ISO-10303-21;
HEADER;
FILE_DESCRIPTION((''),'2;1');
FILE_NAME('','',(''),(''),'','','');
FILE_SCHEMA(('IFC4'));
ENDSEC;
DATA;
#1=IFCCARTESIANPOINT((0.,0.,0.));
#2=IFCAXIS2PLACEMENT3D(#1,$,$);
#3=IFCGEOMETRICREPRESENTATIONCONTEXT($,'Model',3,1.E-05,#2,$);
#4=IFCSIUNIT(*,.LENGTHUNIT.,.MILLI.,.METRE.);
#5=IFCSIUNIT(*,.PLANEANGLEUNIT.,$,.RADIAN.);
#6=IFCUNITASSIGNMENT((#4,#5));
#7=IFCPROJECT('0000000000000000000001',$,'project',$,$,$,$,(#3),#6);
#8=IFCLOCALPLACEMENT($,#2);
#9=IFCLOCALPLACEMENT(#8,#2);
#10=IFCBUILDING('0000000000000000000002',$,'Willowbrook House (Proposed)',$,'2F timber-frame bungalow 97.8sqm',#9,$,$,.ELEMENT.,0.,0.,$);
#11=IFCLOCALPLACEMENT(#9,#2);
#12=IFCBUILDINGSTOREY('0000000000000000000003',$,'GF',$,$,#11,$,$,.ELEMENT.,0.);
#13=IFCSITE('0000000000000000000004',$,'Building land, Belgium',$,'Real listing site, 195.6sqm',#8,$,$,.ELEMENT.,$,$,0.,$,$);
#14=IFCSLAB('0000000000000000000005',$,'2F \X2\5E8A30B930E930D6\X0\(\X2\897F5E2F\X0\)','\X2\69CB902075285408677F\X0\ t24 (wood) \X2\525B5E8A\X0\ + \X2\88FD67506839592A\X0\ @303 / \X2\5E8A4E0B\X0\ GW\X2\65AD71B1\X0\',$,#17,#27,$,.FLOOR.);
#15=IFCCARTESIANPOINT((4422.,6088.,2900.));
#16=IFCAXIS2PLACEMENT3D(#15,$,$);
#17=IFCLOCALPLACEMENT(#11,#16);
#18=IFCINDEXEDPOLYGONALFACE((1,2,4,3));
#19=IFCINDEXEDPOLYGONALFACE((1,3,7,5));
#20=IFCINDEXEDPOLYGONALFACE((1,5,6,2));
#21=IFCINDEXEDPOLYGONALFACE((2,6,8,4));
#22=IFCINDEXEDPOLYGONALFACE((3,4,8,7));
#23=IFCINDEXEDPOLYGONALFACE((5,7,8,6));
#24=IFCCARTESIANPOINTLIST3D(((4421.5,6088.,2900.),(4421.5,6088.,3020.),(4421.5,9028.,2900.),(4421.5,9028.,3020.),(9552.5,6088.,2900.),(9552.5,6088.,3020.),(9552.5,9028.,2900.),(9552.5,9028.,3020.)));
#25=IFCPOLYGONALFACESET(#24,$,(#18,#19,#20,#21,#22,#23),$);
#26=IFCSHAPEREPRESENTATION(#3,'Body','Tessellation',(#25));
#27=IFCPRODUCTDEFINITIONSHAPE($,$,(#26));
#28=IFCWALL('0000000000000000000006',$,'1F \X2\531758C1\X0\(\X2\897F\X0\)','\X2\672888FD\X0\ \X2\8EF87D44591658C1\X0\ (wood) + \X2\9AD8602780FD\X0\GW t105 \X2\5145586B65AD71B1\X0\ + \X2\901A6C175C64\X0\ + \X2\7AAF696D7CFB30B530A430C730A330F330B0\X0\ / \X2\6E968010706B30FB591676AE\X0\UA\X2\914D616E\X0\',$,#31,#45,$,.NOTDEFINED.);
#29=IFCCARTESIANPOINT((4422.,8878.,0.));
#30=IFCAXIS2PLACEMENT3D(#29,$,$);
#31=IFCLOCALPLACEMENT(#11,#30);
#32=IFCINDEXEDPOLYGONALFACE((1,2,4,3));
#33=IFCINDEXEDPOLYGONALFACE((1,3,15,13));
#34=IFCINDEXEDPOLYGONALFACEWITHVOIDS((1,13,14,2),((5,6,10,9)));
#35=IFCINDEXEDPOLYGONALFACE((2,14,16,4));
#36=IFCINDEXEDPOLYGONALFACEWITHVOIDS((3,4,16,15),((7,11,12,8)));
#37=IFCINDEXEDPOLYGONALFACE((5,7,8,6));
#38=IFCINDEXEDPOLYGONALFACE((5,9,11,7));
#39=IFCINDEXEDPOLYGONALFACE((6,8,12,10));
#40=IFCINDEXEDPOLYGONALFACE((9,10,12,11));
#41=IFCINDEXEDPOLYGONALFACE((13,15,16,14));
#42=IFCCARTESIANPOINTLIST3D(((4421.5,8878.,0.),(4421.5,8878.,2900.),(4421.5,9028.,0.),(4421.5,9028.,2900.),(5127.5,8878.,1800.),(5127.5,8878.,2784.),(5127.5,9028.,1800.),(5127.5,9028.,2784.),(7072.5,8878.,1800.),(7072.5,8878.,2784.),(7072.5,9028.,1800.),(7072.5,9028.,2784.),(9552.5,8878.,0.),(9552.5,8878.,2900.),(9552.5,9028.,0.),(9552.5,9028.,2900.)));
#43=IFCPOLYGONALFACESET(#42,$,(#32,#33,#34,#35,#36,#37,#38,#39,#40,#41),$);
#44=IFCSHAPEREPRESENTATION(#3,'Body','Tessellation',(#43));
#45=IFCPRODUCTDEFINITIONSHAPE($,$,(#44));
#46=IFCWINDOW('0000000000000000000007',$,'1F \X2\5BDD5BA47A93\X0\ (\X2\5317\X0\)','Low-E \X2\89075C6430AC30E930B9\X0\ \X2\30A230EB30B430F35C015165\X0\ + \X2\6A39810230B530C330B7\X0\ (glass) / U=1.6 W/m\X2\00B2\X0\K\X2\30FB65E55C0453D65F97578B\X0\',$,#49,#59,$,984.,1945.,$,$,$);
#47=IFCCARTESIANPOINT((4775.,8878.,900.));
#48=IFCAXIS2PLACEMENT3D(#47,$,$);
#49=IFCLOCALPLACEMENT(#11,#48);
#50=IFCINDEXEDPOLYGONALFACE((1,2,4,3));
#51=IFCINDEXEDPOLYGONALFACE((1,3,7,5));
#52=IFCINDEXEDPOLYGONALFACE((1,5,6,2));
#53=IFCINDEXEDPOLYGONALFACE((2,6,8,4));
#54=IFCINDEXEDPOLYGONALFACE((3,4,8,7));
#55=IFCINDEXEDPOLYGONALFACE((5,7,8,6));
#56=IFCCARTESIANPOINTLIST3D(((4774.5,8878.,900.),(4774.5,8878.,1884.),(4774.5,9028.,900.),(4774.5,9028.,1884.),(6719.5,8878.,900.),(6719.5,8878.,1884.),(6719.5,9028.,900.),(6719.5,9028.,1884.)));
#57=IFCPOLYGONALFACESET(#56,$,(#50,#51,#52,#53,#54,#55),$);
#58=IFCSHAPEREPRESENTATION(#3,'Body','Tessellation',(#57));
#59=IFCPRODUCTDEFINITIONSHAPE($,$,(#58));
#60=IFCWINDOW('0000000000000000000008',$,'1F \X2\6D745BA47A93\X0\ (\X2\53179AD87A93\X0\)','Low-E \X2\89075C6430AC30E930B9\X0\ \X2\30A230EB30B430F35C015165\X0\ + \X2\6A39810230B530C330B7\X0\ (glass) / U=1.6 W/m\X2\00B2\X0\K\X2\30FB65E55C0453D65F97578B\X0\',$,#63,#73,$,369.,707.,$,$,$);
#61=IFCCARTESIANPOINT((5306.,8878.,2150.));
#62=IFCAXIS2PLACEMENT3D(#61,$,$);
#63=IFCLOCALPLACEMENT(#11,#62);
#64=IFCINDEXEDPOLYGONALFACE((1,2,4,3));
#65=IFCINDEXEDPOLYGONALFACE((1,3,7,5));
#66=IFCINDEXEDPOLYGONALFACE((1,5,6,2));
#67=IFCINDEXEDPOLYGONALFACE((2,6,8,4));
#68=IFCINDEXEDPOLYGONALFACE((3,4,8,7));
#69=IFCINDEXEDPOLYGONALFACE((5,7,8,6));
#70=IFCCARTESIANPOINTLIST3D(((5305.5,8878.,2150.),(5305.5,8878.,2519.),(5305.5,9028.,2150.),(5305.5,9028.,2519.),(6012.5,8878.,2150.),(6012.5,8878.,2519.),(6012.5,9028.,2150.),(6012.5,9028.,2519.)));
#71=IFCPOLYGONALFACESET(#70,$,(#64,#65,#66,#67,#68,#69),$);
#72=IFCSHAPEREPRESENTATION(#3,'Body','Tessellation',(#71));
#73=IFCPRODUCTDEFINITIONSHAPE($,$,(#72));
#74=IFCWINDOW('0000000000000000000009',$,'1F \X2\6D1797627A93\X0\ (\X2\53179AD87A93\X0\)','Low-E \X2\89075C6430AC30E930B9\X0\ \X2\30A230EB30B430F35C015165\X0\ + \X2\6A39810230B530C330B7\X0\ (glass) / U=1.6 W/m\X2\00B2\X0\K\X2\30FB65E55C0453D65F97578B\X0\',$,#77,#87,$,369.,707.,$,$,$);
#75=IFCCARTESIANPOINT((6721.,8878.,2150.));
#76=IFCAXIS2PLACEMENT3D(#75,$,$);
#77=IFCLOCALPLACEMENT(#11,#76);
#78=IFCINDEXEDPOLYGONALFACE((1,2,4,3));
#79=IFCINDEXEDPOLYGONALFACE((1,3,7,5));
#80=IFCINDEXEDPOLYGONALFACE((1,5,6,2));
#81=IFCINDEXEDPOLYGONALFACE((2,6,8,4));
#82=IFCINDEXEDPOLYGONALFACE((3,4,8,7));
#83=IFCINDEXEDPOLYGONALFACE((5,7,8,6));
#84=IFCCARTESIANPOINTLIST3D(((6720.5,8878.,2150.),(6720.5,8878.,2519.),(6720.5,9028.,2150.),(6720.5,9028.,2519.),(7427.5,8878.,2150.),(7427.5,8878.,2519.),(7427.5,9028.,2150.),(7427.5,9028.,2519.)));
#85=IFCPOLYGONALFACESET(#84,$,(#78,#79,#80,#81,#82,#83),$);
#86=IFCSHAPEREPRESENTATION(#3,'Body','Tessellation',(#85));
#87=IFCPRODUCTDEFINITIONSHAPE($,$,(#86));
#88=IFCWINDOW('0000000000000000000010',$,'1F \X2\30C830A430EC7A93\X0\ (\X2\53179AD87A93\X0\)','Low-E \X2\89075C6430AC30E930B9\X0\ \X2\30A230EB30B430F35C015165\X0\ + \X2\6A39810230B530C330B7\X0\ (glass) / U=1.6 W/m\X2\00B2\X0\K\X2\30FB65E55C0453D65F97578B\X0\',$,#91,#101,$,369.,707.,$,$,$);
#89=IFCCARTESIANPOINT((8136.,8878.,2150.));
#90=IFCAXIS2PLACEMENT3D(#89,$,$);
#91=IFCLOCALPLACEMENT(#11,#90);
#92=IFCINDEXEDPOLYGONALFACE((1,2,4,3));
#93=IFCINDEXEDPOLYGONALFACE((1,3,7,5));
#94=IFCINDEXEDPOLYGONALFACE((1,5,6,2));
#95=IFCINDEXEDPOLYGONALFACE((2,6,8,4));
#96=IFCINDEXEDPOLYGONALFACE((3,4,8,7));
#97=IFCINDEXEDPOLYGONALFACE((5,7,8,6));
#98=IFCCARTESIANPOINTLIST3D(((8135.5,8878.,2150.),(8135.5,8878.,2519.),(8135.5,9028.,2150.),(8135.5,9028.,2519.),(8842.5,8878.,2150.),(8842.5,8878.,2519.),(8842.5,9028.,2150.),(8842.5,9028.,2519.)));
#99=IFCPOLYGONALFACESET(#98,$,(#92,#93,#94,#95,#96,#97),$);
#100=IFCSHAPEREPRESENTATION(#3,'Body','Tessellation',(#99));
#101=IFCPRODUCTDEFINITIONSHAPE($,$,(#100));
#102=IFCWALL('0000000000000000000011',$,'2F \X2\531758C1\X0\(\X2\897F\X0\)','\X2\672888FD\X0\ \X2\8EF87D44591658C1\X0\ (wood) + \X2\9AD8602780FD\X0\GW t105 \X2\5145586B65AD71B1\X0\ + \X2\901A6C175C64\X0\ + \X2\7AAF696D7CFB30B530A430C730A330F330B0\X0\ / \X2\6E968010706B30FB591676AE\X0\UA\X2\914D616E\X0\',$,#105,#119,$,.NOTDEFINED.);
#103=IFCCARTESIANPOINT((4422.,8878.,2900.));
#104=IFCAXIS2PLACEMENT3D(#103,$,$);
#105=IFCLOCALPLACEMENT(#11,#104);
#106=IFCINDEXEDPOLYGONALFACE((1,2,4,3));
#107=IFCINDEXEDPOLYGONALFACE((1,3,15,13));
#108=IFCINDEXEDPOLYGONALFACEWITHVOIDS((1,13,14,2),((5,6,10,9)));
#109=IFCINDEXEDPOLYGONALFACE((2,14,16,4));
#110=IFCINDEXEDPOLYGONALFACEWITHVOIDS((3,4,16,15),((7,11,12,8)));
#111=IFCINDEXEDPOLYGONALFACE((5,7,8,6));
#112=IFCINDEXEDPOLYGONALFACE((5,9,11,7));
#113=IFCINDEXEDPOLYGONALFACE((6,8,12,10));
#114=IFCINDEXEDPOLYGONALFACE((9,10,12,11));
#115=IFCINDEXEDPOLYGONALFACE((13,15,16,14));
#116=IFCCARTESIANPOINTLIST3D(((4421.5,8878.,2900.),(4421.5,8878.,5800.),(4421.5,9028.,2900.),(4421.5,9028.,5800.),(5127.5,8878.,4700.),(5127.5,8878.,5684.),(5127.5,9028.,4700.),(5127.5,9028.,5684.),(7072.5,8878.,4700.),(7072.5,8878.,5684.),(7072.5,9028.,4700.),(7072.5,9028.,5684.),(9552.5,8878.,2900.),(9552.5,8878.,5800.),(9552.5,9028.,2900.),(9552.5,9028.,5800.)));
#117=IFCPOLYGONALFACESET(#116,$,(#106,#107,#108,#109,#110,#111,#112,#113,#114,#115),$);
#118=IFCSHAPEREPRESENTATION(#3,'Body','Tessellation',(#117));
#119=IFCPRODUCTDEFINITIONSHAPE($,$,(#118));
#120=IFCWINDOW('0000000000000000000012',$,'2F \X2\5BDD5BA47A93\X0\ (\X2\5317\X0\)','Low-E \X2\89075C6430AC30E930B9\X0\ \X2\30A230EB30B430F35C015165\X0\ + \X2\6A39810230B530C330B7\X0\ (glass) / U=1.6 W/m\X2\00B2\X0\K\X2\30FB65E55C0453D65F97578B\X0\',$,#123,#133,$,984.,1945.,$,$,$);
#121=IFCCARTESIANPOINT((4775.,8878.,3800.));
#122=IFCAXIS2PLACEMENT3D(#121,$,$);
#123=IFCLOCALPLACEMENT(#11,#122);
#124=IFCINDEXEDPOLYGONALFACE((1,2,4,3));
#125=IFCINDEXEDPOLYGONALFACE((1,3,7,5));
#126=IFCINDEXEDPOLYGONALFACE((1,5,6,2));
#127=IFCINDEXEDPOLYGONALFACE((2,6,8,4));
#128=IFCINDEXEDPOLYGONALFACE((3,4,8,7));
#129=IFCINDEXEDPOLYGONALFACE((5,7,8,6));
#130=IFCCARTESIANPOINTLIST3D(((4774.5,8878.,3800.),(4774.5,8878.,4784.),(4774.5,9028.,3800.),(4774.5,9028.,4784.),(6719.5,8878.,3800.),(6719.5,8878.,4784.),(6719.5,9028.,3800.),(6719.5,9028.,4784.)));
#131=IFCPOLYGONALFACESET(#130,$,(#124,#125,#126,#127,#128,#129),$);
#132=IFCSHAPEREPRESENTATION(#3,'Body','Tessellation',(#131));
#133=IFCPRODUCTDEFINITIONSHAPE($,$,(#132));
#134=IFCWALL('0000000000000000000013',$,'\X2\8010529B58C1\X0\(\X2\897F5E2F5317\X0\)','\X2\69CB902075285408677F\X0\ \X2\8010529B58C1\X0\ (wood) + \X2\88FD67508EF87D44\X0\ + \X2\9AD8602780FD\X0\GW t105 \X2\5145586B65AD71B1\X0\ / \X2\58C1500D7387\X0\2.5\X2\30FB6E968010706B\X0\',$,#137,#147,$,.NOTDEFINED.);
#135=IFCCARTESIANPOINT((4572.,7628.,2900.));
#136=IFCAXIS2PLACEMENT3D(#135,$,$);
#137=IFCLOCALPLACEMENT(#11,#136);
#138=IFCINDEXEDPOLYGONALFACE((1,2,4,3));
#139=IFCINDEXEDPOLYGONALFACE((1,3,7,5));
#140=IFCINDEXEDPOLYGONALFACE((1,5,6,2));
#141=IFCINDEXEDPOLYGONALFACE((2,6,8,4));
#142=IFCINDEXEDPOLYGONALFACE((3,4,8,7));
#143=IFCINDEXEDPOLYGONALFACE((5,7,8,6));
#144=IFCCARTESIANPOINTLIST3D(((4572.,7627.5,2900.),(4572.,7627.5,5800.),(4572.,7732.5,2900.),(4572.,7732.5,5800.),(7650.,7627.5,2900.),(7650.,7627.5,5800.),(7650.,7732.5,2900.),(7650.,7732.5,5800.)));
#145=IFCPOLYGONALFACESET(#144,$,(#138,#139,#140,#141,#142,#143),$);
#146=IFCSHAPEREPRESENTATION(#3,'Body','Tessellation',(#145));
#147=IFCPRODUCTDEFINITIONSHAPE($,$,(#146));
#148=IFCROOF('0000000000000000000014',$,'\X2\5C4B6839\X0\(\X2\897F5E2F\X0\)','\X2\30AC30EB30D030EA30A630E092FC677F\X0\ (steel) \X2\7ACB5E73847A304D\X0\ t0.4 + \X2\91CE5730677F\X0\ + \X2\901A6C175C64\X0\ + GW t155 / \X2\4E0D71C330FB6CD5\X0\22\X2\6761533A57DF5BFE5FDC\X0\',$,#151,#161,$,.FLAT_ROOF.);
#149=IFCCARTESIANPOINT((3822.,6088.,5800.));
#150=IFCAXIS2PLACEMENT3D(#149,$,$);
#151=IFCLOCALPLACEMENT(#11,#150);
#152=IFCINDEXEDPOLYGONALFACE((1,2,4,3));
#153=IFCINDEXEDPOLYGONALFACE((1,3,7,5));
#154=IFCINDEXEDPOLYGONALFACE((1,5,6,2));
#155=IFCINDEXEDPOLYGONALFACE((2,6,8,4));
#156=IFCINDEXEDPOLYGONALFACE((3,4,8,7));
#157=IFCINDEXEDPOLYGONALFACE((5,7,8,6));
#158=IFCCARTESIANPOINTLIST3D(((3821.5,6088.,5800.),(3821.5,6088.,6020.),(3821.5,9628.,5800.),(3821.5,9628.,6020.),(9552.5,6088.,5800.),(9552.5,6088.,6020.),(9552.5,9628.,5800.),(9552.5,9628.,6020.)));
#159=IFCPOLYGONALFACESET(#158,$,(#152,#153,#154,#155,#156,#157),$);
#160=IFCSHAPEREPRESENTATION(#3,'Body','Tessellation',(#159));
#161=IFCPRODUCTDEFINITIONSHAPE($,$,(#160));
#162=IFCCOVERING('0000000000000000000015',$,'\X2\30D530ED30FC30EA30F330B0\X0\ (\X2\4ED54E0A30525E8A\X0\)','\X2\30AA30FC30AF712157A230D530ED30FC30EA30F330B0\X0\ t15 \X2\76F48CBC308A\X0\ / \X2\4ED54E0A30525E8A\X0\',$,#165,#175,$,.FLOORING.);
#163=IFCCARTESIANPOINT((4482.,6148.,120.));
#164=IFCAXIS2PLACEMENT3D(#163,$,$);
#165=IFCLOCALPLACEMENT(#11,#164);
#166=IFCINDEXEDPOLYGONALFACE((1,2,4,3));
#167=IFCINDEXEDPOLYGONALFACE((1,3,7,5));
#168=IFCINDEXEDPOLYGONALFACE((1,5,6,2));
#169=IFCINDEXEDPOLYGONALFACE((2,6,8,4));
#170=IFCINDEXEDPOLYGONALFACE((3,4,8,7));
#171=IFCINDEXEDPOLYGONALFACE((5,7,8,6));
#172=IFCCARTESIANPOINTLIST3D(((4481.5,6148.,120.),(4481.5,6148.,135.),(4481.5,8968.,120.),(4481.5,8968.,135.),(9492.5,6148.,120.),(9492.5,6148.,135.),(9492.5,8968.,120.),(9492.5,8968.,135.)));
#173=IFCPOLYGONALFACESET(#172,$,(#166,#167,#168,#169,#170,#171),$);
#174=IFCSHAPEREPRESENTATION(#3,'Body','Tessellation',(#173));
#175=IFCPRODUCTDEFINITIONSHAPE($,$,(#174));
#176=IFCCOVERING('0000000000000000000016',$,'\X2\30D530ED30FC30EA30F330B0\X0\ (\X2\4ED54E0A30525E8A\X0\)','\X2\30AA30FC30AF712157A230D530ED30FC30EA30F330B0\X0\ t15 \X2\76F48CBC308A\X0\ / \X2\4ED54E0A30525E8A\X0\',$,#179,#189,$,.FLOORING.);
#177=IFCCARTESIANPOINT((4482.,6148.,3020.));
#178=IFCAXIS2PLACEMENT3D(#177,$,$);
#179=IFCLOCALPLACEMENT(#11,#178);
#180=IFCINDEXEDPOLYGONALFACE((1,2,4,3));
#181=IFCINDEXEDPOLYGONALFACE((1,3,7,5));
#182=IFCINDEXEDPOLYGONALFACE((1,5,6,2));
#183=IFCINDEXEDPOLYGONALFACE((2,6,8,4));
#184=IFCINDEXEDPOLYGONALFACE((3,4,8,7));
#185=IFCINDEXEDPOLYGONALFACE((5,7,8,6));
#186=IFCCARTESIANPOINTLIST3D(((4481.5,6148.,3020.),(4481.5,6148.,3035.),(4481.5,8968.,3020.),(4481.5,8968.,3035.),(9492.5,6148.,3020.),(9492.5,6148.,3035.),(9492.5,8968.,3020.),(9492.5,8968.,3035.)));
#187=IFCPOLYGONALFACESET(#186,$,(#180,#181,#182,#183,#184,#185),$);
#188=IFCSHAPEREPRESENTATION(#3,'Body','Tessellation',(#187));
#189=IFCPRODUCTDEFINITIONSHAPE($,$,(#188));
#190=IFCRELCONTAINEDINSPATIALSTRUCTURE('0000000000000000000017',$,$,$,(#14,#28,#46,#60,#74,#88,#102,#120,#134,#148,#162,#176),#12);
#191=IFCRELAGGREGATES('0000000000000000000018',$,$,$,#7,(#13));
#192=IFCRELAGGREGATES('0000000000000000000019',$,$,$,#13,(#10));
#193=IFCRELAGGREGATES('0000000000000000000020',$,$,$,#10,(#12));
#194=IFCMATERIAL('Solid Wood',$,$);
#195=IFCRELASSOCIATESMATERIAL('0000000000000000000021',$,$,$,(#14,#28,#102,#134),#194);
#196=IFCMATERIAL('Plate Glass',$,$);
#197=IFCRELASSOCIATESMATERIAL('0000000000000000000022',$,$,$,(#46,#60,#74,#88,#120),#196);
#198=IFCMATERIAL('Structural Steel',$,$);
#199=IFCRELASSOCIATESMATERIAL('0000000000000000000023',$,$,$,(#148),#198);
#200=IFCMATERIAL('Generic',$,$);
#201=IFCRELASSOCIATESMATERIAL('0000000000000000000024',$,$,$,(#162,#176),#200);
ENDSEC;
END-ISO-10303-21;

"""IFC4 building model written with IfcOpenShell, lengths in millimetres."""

from ifc_helpers import new_model, si_unit, frame, frame_2d, origin, place, context, project, spatial, rectangle, extrude, material, element, fill, save


model = new_model("IFC4")

# Units and contexts
model_context = context("Model", 3, precision=1e-05, world=origin())
ifc_project = project(units=[si_unit("LENGTHUNIT", "METRE", prefix="MILLI"), si_unit("PLANEANGLEUNIT", "RADIAN")], contexts=[model_context])

# Site, building, storey
site_placement = place(None, origin())
site = spatial("IfcSite", under=ifc_project, at=site_placement, Name="Building land, Belgium", ObjectType="Real listing site, 195.6sqm", CompositionType="ELEMENT", RefElevation=0.0)
building_placement = place(site_placement, origin())
building = spatial("IfcBuilding", under=site, at=building_placement, Name="Willowbrook House (Proposed)", ObjectType="2F timber-frame bungalow 97.8sqm", CompositionType="ELEMENT", ElevationOfRefHeight=0.0, ElevationOfTerrain=0.0)
storey_placement = place(building_placement, origin())
storey = spatial("IfcBuildingStorey", under=building, at=storey_placement, Name="GF", CompositionType="ELEMENT", Elevation=0.0)

# Slab
ifc_material_1 = material(Name="Solid Wood")
slab_1_placement = place(storey_placement, frame((4422.0, 6088.0, 2900.0)))
element("IfcSlab", 1, at=slab_1_placement, inside=storey, material=ifc_material_1, Name="2F 床スラブ(西帯)", Description="構造用合板 t24 (wood) 剛床 + 製材根太 @303 / 床下 GW断熱", PredefinedType="FLOOR", context=model_context, shape_type="SweptSolid", body=[
    extrude(rectangle(XDim=5131.0, YDim=2940.0, at=frame_2d((2565.0, 1470.0))), frame((4422.0, 6088.0, 2900.0)), (0.0, 0.0, 1.0), 120.0),
])

# Wall, openings, windows
wall_1_placement = place(storey_placement, frame((4422.0, 8878.0, 0.0)))
wall_1 = element("IfcWall", 2, at=wall_1_placement, inside=storey, material=ifc_material_1, Name="1F 北壁(西)", Description="木製 軸組外壁 (wood) + 高性能GW t105 充填断熱 + 通気層 + 窯業系サイディング / 準耐火・外皮UA配慮", PredefinedType="NOTDEFINED", context=model_context, shape_type="SweptSolid", body=[
    extrude(rectangle(XDim=5131.0, YDim=150.0, at=frame_2d((2565.0, 75.0))), frame((4422.0, 8878.0, 0.0)), (0.0, 0.0, 1.0), 2900.0),
])
opening_1_placement = place(storey_placement, frame((4775.0, 8878.0, 900.0)))
opening_1 = element("IfcOpeningElement", 3, at=opening_1_placement, cuts=wall_1, PredefinedType="NOTDEFINED", context=model_context, shape_type="SweptSolid", body=[
    extrude(rectangle(XDim=1945.0, YDim=150.0, at=frame_2d((972.0, 75.0))), frame((4775.0, 8878.0, 900.0)), (0.0, 0.0, 1.0), 984.0),
])
opening_2_placement = place(storey_placement, frame((5306.0, 8878.0, 2150.0)))
opening_2 = element("IfcOpeningElement", 4, at=opening_2_placement, cuts=wall_1, PredefinedType="NOTDEFINED", context=model_context, shape_type="SweptSolid", body=[
    extrude(rectangle(XDim=707.0, YDim=150.0, at=frame_2d((353.0, 75.0))), frame((5306.0, 8878.0, 2150.0)), (0.0, 0.0, 1.0), 369.0),
])
opening_3_placement = place(storey_placement, frame((6721.0, 8878.0, 2150.0)))
opening_3 = element("IfcOpeningElement", 5, at=opening_3_placement, cuts=wall_1, PredefinedType="NOTDEFINED", context=model_context, shape_type="SweptSolid", body=[
    extrude(rectangle(XDim=707.0, YDim=150.0, at=frame_2d((353.0, 75.0))), frame((6721.0, 8878.0, 2150.0)), (0.0, 0.0, 1.0), 369.0),
])
opening_4_placement = place(storey_placement, frame((8136.0, 8878.0, 2150.0)))
opening_4 = element("IfcOpeningElement", 6, at=opening_4_placement, cuts=wall_1, PredefinedType="NOTDEFINED", context=model_context, shape_type="SweptSolid", body=[
    extrude(rectangle(XDim=707.0, YDim=150.0, at=frame_2d((353.0, 75.0))), frame((8136.0, 8878.0, 2150.0)), (0.0, 0.0, 1.0), 369.0),
])
ifc_material_2 = material(Name="Plate Glass")
window_1_placement = place(storey_placement, frame((4775.0, 8878.0, 900.0)))
window_1 = element("IfcWindow", 7, at=window_1_placement, inside=storey, material=ifc_material_2, Name="1F 寝室窓 (北)", Description="Low-E 複層ガラス アルゴン封入 + 樹脂サッシ (glass) / U=1.6 W/m²K・日射取得型", OverallHeight=984.0, OverallWidth=1945.0, context=model_context, shape_type="SweptSolid", body=[
    extrude(rectangle(XDim=1945.0, YDim=150.0, at=frame_2d((972.0, 75.0))), frame((4775.0, 8878.0, 900.0)), (0.0, 0.0, 1.0), 984.0),
])
fill(opening_1, window_1)
window_2_placement = place(storey_placement, frame((5306.0, 8878.0, 2150.0)))
window_2 = element("IfcWindow", 8, at=window_2_placement, inside=storey, material=ifc_material_2, Name="1F 浴室窓 (北高窓)", Description="Low-E 複層ガラス アルゴン封入 + 樹脂サッシ (glass) / U=1.6 W/m²K・日射取得型", OverallHeight=369.0, OverallWidth=707.0, context=model_context, shape_type="SweptSolid", body=[
    extrude(rectangle(XDim=707.0, YDim=150.0, at=frame_2d((353.0, 75.0))), frame((5306.0, 8878.0, 2150.0)), (0.0, 0.0, 1.0), 369.0),
])
fill(opening_2, window_2)
window_3_placement = place(storey_placement, frame((6721.0, 8878.0, 2150.0)))
window_3 = element("IfcWindow", 9, at=window_3_placement, inside=storey, material=ifc_material_2, Name="1F 洗面窓 (北高窓)", Description="Low-E 複層ガラス アルゴン封入 + 樹脂サッシ (glass) / U=1.6 W/m²K・日射取得型", OverallHeight=369.0, OverallWidth=707.0, context=model_context, shape_type="SweptSolid", body=[
    extrude(rectangle(XDim=707.0, YDim=150.0, at=frame_2d((353.0, 75.0))), frame((6721.0, 8878.0, 2150.0)), (0.0, 0.0, 1.0), 369.0),
])
fill(opening_3, window_3)
window_4_placement = place(storey_placement, frame((8136.0, 8878.0, 2150.0)))
window_4 = element("IfcWindow", 10, at=window_4_placement, inside=storey, material=ifc_material_2, Name="1F トイレ窓 (北高窓)", Description="Low-E 複層ガラス アルゴン封入 + 樹脂サッシ (glass) / U=1.6 W/m²K・日射取得型", OverallHeight=369.0, OverallWidth=707.0, context=model_context, shape_type="SweptSolid", body=[
    extrude(rectangle(XDim=707.0, YDim=150.0, at=frame_2d((353.0, 75.0))), frame((8136.0, 8878.0, 2150.0)), (0.0, 0.0, 1.0), 369.0),
])
fill(opening_4, window_4)

# Wall, opening, window
wall_2_placement = place(storey_placement, frame((4422.0, 8878.0, 2900.0)))
wall_2 = element("IfcWall", 11, at=wall_2_placement, inside=storey, material=ifc_material_1, Name="2F 北壁(西)", Description="木製 軸組外壁 (wood) + 高性能GW t105 充填断熱 + 通気層 + 窯業系サイディング / 準耐火・外皮UA配慮", PredefinedType="NOTDEFINED", context=model_context, shape_type="SweptSolid", body=[
    extrude(rectangle(XDim=5131.0, YDim=150.0, at=frame_2d((2565.0, 75.0))), frame((4422.0, 8878.0, 2900.0)), (0.0, 0.0, 1.0), 2900.0),
])
opening_5_placement = place(storey_placement, frame((4775.0, 8878.0, 3800.0)))
opening_5 = element("IfcOpeningElement", 12, at=opening_5_placement, cuts=wall_2, PredefinedType="NOTDEFINED", context=model_context, shape_type="SweptSolid", body=[
    extrude(rectangle(XDim=1945.0, YDim=150.0, at=frame_2d((972.0, 75.0))), frame((4775.0, 8878.0, 3800.0)), (0.0, 0.0, 1.0), 984.0),
])
window_5_placement = place(storey_placement, frame((4775.0, 8878.0, 3800.0)))
window_5 = element("IfcWindow", 13, at=window_5_placement, inside=storey, material=ifc_material_2, Name="2F 寝室窓 (北)", Description="Low-E 複層ガラス アルゴン封入 + 樹脂サッシ (glass) / U=1.6 W/m²K・日射取得型", OverallHeight=984.0, OverallWidth=1945.0, context=model_context, shape_type="SweptSolid", body=[
    extrude(rectangle(XDim=1945.0, YDim=150.0, at=frame_2d((972.0, 75.0))), frame((4775.0, 8878.0, 3800.0)), (0.0, 0.0, 1.0), 984.0),
])
fill(opening_5, window_5)

# Wall
wall_3_placement = place(storey_placement, frame((4572.0, 7628.0, 2900.0)))
element("IfcWall", 14, at=wall_3_placement, inside=storey, material=ifc_material_1, Name="耐力壁(西帯北)", Description="構造用合板 耐力壁 (wood) + 製材軸組 + 高性能GW t105 充填断熱 / 壁倍率2.5・準耐火", PredefinedType="NOTDEFINED", context=model_context, shape_type="SweptSolid", body=[
    extrude(rectangle(XDim=3078.0, YDim=105.0, at=frame_2d((1539.0, 52.0))), frame((4572.0, 7628.0, 2900.0)), (0.0, 0.0, 1.0), 2900.0),
])

# Roof
ifc_material_3 = material(Name="Structural Steel")
for number, where, name in (
    (15, (3822.0, 6088.0, 5800.0), "屋根(西帯)"),
):
    element("IfcRoof", number, at=place(storey_placement, frame(where)), inside=storey, material=ifc_material_3, Name=name, Description="ガルバリウム鋼板 (steel) 立平葺き t0.4 + 野地板 + 通気層 + GW t155 / 不燃・法22条区域対応", PredefinedType="FLAT_ROOF", context=model_context, shape_type="SweptSolid", body=[
        extrude(rectangle(XDim=5731.0, YDim=3540.0, at=frame_2d((2865.0, 1770.0))), frame((3822.0, 6088.0, 5800.0)), (0.0, 0.0, 1.0), 220.0),
    ])

# Coverings
ifc_material_4 = material(Name="Generic")
covering_1_placement = place(storey_placement, frame((4482.0, 6148.0, 120.0)))
element("IfcCovering", 16, at=covering_1_placement, inside=storey, material=ifc_material_4, Name="フローリング (仕上げ床)", Description="オーク無垢フローリング t15 直貼り / 仕上げ床", PredefinedType="FLOORING", context=model_context, shape_type="SweptSolid", body=[
    extrude(rectangle(XDim=5011.0, YDim=2820.0, at=frame_2d((2505.0, 1410.0))), frame((4482.0, 6148.0, 120.0)), (0.0, 0.0, 1.0), 15.0),
])
covering_2_placement = place(storey_placement, frame((4482.0, 6148.0, 3020.0)))
element("IfcCovering", 17, at=covering_2_placement, inside=storey, material=ifc_material_4, Name="フローリング (仕上げ床)", Description="オーク無垢フローリング t15 直貼り / 仕上げ床", PredefinedType="FLOORING", context=model_context, shape_type="SweptSolid", body=[
    extrude(rectangle(XDim=5011.0, YDim=2820.0, at=frame_2d((2505.0, 1410.0))), frame((4482.0, 6148.0, 3020.0)), (0.0, 0.0, 1.0), 15.0),
])

save(model, "model.ifc")
